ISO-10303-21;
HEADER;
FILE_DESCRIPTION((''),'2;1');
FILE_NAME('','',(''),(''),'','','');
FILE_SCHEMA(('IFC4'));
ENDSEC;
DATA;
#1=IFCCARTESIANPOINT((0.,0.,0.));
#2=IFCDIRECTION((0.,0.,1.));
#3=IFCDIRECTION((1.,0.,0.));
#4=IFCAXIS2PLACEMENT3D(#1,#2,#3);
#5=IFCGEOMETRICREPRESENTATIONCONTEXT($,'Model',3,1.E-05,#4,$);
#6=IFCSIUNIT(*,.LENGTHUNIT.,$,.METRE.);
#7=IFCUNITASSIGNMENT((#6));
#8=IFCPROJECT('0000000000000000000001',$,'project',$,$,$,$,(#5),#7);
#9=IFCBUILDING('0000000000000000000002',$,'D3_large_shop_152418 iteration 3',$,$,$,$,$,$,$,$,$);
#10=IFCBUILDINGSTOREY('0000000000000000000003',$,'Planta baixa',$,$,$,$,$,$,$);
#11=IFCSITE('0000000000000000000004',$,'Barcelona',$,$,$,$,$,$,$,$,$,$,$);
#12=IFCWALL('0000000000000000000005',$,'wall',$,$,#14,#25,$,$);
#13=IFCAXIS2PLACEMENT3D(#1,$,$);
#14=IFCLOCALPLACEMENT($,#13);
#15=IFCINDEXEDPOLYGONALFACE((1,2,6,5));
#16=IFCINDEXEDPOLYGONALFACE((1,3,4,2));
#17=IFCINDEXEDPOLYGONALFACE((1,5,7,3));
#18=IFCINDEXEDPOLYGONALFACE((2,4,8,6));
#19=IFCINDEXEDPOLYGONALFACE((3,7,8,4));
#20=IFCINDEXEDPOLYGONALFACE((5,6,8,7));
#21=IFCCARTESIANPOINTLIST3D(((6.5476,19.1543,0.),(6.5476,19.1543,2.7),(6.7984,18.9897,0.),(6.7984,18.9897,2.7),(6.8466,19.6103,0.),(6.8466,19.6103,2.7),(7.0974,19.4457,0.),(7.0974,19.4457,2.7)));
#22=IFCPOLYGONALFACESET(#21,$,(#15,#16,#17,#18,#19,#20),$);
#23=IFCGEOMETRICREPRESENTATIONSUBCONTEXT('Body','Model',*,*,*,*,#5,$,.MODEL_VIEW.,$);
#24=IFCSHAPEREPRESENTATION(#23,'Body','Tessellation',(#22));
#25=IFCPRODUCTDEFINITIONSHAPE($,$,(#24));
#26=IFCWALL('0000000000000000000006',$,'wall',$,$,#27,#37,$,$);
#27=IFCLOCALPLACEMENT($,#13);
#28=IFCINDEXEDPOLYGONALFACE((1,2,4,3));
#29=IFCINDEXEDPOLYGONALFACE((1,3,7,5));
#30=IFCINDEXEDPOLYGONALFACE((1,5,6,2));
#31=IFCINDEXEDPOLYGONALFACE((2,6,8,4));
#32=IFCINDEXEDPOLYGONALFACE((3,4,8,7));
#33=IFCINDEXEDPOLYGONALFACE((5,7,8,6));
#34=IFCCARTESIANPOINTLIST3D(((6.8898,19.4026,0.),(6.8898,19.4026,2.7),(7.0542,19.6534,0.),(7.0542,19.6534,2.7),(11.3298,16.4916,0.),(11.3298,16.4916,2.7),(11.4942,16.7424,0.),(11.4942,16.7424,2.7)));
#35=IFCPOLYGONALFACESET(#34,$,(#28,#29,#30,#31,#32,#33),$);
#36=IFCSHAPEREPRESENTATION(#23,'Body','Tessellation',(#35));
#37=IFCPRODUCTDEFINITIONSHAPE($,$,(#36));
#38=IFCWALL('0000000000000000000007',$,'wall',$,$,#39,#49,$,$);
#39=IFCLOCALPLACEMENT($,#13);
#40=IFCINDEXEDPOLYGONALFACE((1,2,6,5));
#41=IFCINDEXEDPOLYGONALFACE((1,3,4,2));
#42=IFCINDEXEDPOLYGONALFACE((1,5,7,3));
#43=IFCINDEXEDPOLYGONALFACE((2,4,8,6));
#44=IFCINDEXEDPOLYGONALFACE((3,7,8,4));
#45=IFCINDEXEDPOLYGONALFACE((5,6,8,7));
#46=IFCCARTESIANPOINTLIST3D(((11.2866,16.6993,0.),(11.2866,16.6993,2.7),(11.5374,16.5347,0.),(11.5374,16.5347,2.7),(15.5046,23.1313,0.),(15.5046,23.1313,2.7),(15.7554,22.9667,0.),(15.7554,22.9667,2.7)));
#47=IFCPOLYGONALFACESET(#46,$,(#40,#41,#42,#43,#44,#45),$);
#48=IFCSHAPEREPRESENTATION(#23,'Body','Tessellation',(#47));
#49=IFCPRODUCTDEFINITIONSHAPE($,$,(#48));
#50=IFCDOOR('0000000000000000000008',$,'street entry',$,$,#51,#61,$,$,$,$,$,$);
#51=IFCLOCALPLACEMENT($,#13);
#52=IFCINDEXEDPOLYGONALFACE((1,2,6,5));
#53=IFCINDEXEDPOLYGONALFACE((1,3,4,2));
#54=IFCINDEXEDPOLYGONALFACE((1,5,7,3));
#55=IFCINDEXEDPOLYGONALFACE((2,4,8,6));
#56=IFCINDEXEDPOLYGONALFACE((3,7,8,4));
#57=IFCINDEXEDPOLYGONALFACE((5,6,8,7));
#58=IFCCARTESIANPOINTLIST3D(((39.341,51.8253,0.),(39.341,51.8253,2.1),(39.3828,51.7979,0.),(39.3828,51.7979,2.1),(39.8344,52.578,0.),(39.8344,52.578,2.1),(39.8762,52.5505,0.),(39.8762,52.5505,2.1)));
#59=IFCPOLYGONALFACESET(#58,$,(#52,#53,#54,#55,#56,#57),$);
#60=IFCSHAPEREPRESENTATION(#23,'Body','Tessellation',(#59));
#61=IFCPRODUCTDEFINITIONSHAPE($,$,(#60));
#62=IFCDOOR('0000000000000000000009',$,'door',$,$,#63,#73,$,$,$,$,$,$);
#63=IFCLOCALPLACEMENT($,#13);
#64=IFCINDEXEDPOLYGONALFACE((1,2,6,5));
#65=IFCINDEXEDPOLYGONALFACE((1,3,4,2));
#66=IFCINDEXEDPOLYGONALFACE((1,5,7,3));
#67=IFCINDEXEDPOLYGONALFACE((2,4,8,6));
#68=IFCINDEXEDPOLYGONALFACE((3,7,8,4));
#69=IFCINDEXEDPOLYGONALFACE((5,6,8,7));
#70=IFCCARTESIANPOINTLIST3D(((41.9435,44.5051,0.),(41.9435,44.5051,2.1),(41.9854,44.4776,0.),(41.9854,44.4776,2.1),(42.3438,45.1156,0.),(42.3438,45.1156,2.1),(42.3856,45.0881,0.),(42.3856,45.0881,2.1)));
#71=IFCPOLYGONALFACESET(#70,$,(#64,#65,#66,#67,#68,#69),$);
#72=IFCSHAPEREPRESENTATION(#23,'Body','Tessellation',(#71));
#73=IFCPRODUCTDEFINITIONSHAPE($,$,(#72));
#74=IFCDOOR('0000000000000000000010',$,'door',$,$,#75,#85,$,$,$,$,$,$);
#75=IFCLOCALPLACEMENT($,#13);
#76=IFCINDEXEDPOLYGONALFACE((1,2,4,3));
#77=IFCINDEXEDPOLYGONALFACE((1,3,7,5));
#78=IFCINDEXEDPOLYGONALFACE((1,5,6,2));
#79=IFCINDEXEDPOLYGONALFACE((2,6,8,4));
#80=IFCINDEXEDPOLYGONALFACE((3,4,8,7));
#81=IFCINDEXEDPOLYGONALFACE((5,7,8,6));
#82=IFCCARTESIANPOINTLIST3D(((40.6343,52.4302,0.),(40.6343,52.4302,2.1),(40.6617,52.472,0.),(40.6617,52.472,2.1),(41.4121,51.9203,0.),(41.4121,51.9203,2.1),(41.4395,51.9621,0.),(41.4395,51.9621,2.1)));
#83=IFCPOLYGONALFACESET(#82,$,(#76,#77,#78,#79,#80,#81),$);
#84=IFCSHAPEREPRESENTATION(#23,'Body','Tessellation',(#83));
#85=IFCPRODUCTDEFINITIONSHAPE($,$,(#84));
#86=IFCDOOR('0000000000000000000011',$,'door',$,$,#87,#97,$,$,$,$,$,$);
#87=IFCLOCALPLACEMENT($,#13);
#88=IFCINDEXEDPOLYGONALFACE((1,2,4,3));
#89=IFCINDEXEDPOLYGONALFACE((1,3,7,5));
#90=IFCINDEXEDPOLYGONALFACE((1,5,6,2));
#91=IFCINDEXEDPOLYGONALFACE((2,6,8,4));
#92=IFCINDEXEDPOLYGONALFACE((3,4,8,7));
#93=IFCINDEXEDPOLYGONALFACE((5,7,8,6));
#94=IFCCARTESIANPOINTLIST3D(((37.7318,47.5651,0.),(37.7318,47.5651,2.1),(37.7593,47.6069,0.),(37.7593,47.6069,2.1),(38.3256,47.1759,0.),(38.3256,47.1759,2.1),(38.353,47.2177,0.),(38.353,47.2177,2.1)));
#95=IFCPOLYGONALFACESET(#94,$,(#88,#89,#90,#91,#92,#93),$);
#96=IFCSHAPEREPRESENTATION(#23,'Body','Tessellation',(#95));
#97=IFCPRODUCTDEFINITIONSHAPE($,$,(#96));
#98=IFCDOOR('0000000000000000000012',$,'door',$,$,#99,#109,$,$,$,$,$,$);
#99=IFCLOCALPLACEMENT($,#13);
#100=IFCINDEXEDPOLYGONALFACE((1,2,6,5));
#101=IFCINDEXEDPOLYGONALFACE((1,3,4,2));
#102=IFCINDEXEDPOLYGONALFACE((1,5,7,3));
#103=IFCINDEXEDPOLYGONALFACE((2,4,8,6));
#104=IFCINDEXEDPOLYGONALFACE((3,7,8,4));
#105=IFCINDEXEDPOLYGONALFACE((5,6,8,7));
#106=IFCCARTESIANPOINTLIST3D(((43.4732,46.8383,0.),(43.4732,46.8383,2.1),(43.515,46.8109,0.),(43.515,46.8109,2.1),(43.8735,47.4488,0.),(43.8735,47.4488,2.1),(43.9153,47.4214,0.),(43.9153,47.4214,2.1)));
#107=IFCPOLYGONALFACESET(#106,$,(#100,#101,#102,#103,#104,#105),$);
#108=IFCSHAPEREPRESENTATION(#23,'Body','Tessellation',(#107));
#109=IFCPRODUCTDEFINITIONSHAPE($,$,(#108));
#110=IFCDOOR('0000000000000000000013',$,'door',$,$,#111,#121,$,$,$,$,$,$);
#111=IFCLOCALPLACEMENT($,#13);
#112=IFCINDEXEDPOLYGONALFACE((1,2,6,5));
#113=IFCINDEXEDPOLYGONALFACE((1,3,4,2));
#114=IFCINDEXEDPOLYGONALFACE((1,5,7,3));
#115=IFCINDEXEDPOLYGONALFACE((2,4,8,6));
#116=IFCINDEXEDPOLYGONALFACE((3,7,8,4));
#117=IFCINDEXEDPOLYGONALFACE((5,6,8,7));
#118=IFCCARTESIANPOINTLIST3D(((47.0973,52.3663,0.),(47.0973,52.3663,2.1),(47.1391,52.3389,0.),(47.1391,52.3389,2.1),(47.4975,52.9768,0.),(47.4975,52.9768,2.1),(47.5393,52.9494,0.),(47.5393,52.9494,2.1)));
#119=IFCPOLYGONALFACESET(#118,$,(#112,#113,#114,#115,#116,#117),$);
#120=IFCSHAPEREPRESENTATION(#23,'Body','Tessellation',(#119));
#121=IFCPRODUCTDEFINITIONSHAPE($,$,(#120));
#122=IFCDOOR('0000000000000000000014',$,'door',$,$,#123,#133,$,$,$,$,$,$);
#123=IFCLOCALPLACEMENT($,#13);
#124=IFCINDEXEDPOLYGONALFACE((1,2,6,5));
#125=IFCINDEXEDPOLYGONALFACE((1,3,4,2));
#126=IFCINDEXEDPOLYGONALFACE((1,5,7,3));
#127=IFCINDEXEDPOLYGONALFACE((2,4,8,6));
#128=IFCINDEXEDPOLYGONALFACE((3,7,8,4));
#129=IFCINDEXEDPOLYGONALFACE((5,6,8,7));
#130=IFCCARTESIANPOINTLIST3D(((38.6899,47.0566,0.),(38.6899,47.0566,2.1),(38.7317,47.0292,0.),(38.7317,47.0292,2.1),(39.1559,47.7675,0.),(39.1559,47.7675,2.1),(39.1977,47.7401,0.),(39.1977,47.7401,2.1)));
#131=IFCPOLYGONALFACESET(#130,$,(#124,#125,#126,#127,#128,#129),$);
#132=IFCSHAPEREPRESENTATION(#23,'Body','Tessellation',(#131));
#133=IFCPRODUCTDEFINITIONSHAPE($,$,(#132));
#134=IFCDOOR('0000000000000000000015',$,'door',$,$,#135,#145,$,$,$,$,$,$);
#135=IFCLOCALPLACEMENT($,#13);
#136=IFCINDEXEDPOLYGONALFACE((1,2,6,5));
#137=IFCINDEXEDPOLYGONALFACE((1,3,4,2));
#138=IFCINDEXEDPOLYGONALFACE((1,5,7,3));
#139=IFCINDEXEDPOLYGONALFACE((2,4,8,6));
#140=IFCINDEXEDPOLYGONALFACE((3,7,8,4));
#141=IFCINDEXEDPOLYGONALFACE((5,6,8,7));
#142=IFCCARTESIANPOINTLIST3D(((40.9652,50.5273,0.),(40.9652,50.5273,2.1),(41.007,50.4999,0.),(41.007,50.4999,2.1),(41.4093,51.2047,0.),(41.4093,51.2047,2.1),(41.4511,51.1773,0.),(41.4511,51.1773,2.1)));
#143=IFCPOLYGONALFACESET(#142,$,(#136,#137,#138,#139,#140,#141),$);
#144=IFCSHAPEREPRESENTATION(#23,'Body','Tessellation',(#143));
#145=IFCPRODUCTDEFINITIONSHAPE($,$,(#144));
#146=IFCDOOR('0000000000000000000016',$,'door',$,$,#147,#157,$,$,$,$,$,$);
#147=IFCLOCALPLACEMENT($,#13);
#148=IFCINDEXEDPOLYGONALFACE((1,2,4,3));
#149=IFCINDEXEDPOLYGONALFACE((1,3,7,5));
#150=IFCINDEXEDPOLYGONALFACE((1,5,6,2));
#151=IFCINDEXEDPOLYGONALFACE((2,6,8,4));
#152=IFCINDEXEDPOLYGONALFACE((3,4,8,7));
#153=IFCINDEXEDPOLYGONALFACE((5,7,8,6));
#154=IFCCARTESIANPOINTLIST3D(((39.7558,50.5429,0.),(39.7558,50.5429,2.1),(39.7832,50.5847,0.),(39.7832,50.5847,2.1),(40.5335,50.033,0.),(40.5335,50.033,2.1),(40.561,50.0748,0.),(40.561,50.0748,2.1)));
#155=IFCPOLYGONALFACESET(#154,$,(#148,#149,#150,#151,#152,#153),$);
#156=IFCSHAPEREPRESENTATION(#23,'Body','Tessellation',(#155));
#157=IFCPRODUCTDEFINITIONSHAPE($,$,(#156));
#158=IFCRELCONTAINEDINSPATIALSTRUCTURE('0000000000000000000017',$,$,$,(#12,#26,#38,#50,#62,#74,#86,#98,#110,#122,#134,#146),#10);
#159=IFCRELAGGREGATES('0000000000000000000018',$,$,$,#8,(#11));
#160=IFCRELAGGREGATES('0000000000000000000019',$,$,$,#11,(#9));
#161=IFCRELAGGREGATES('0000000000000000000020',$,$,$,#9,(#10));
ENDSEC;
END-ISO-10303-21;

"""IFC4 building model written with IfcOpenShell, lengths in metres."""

from ifc_helpers import new_model, si_unit, origin, origin_with_axes, place, context, subcontext, project, spatial, polyline, outline, extrude, element, save


model = new_model("IFC4")

# Units and contexts
model_context = context("Model", 3, precision=1e-05, world=origin_with_axes())
body_context = subcontext(model_context, "Body", "Model", "MODEL_VIEW")
ifc_project = project(units=[si_unit("LENGTHUNIT", "METRE")], contexts=[model_context])

# Site, building, storey
site = spatial("IfcSite", under=ifc_project, Name="Barcelona")
building = spatial("IfcBuilding", under=site, Name="D3_large_shop_152418 iteration 3")
storey = spatial("IfcBuildingStorey", under=building, Name="Planta baixa")

# Walls
wall_1_placement = place(None, origin_with_axes())
element("IfcWall", 1, at=wall_1_placement, inside=storey, Name="wall", context=body_context, shape_type="SweptSolid", body=[
    extrude(outline(polyline([(6.5476, 19.1543), (6.8466, 19.6103), (7.0974, 19.4457), (6.7984, 18.9897), (6.5476, 19.1543)])), origin(), (0.0, 0.0, 1.0), 2.7),
])
wall_2_placement = place(None, origin_with_axes())
element("IfcWall", 2, at=wall_2_placement, inside=storey, Name="wall", context=body_context, shape_type="SweptSolid", body=[
    extrude(outline(polyline([(7.0542, 19.6534), (11.4942, 16.7424), (11.3298, 16.4916), (6.8898, 19.4026), (7.0542, 19.6534)])), origin(), (0.0, 0.0, 1.0), 2.7),
])
wall_3_placement = place(None, origin_with_axes())
element("IfcWall", 3, at=wall_3_placement, inside=storey, Name="wall", context=body_context, shape_type="SweptSolid", body=[
    extrude(outline(polyline([(11.2866, 16.6993), (15.5046, 23.1313), (15.7554, 22.9667), (11.5374, 16.5347), (11.2866, 16.6993)])), origin(), (0.0, 0.0, 1.0), 2.7),
])

# Doors
door_1_placement = place(None, origin_with_axes())
element("IfcDoor", 4, at=door_1_placement, inside=storey, Name="street entry", context=body_context, shape_type="SweptSolid", body=[
    extrude(outline(polyline([(39.8762, 52.5505), (39.3828, 51.7979), (39.341, 51.8253), (39.8344, 52.578), (39.8762, 52.5505)])), origin(), (0.0, 0.0, 1.0), 2.1),
])
door_2_placement = place(None, origin_with_axes())
element("IfcDoor", 5, at=door_2_placement, inside=storey, Name="door", context=body_context, shape_type="SweptSolid", body=[
    extrude(outline(polyline([(41.9435, 44.5051), (42.3438, 45.1156), (42.3856, 45.0881), (41.9854, 44.4776), (41.9435, 44.5051)])), origin(), (0.0, 0.0, 1.0), 2.1),
])
door_3_placement = place(None, origin_with_axes())
element("IfcDoor", 6, at=door_3_placement, inside=storey, Name="door", context=body_context, shape_type="SweptSolid", body=[
    extrude(outline(polyline([(40.6617, 52.472), (41.4395, 51.9621), (41.4121, 51.9203), (40.6343, 52.4302), (40.6617, 52.472)])), origin(), (0.0, 0.0, 1.0), 2.1),
])
door_4_placement = place(None, origin_with_axes())
element("IfcDoor", 7, at=door_4_placement, inside=storey, Name="door", context=body_context, shape_type="SweptSolid", body=[
    extrude(outline(polyline([(37.7593, 47.6069), (38.353, 47.2177), (38.3256, 47.1759), (37.7318, 47.5651), (37.7593, 47.6069)])), origin(), (0.0, 0.0, 1.0), 2.1),
])
door_5_placement = place(None, origin_with_axes())
element("IfcDoor", 8, at=door_5_placement, inside=storey, Name="door", context=body_context, shape_type="SweptSolid", body=[
    extrude(outline(polyline([(43.4732, 46.8383), (43.8735, 47.4488), (43.9153, 47.4214), (43.515, 46.8109), (43.4732, 46.8383)])), origin(), (0.0, 0.0, 1.0), 2.1),
])
door_6_placement = place(None, origin_with_axes())
element("IfcDoor", 9, at=door_6_placement, inside=storey, Name="door", context=body_context, shape_type="SweptSolid", body=[
    extrude(outline(polyline([(47.5393, 52.9494), (47.1391, 52.3389), (47.0973, 52.3663), (47.4975, 52.9768), (47.5393, 52.9494)])), origin(), (0.0, 0.0, 1.0), 2.1),
])
door_7_placement = place(None, origin_with_axes())
element("IfcDoor", 10, at=door_7_placement, inside=storey, Name="door", context=body_context, shape_type="SweptSolid", body=[
    extrude(outline(polyline([(39.1977, 47.7401), (38.7317, 47.0292), (38.6899, 47.0566), (39.1559, 47.7675), (39.1977, 47.7401)])), origin(), (0.0, 0.0, 1.0), 2.1),
])
door_8_placement = place(None, origin_with_axes())
element("IfcDoor", 11, at=door_8_placement, inside=storey, Name="door", context=body_context, shape_type="SweptSolid", body=[
    extrude(outline(polyline([(40.9652, 50.5273), (41.4093, 51.2047), (41.4511, 51.1773), (41.007, 50.4999), (40.9652, 50.5273)])), origin(), (0.0, 0.0, 1.0), 2.1),
])
door_9_placement = place(None, origin_with_axes())
element("IfcDoor", 12, at=door_9_placement, inside=storey, Name="door", context=body_context, shape_type="SweptSolid", body=[
    extrude(outline(polyline([(39.7832, 50.5847), (40.561, 50.0748), (40.5335, 50.033), (39.7558, 50.5429), (39.7832, 50.5847)])), origin(), (0.0, 0.0, 1.0), 2.1),
])

save(model, "model.ifc")
